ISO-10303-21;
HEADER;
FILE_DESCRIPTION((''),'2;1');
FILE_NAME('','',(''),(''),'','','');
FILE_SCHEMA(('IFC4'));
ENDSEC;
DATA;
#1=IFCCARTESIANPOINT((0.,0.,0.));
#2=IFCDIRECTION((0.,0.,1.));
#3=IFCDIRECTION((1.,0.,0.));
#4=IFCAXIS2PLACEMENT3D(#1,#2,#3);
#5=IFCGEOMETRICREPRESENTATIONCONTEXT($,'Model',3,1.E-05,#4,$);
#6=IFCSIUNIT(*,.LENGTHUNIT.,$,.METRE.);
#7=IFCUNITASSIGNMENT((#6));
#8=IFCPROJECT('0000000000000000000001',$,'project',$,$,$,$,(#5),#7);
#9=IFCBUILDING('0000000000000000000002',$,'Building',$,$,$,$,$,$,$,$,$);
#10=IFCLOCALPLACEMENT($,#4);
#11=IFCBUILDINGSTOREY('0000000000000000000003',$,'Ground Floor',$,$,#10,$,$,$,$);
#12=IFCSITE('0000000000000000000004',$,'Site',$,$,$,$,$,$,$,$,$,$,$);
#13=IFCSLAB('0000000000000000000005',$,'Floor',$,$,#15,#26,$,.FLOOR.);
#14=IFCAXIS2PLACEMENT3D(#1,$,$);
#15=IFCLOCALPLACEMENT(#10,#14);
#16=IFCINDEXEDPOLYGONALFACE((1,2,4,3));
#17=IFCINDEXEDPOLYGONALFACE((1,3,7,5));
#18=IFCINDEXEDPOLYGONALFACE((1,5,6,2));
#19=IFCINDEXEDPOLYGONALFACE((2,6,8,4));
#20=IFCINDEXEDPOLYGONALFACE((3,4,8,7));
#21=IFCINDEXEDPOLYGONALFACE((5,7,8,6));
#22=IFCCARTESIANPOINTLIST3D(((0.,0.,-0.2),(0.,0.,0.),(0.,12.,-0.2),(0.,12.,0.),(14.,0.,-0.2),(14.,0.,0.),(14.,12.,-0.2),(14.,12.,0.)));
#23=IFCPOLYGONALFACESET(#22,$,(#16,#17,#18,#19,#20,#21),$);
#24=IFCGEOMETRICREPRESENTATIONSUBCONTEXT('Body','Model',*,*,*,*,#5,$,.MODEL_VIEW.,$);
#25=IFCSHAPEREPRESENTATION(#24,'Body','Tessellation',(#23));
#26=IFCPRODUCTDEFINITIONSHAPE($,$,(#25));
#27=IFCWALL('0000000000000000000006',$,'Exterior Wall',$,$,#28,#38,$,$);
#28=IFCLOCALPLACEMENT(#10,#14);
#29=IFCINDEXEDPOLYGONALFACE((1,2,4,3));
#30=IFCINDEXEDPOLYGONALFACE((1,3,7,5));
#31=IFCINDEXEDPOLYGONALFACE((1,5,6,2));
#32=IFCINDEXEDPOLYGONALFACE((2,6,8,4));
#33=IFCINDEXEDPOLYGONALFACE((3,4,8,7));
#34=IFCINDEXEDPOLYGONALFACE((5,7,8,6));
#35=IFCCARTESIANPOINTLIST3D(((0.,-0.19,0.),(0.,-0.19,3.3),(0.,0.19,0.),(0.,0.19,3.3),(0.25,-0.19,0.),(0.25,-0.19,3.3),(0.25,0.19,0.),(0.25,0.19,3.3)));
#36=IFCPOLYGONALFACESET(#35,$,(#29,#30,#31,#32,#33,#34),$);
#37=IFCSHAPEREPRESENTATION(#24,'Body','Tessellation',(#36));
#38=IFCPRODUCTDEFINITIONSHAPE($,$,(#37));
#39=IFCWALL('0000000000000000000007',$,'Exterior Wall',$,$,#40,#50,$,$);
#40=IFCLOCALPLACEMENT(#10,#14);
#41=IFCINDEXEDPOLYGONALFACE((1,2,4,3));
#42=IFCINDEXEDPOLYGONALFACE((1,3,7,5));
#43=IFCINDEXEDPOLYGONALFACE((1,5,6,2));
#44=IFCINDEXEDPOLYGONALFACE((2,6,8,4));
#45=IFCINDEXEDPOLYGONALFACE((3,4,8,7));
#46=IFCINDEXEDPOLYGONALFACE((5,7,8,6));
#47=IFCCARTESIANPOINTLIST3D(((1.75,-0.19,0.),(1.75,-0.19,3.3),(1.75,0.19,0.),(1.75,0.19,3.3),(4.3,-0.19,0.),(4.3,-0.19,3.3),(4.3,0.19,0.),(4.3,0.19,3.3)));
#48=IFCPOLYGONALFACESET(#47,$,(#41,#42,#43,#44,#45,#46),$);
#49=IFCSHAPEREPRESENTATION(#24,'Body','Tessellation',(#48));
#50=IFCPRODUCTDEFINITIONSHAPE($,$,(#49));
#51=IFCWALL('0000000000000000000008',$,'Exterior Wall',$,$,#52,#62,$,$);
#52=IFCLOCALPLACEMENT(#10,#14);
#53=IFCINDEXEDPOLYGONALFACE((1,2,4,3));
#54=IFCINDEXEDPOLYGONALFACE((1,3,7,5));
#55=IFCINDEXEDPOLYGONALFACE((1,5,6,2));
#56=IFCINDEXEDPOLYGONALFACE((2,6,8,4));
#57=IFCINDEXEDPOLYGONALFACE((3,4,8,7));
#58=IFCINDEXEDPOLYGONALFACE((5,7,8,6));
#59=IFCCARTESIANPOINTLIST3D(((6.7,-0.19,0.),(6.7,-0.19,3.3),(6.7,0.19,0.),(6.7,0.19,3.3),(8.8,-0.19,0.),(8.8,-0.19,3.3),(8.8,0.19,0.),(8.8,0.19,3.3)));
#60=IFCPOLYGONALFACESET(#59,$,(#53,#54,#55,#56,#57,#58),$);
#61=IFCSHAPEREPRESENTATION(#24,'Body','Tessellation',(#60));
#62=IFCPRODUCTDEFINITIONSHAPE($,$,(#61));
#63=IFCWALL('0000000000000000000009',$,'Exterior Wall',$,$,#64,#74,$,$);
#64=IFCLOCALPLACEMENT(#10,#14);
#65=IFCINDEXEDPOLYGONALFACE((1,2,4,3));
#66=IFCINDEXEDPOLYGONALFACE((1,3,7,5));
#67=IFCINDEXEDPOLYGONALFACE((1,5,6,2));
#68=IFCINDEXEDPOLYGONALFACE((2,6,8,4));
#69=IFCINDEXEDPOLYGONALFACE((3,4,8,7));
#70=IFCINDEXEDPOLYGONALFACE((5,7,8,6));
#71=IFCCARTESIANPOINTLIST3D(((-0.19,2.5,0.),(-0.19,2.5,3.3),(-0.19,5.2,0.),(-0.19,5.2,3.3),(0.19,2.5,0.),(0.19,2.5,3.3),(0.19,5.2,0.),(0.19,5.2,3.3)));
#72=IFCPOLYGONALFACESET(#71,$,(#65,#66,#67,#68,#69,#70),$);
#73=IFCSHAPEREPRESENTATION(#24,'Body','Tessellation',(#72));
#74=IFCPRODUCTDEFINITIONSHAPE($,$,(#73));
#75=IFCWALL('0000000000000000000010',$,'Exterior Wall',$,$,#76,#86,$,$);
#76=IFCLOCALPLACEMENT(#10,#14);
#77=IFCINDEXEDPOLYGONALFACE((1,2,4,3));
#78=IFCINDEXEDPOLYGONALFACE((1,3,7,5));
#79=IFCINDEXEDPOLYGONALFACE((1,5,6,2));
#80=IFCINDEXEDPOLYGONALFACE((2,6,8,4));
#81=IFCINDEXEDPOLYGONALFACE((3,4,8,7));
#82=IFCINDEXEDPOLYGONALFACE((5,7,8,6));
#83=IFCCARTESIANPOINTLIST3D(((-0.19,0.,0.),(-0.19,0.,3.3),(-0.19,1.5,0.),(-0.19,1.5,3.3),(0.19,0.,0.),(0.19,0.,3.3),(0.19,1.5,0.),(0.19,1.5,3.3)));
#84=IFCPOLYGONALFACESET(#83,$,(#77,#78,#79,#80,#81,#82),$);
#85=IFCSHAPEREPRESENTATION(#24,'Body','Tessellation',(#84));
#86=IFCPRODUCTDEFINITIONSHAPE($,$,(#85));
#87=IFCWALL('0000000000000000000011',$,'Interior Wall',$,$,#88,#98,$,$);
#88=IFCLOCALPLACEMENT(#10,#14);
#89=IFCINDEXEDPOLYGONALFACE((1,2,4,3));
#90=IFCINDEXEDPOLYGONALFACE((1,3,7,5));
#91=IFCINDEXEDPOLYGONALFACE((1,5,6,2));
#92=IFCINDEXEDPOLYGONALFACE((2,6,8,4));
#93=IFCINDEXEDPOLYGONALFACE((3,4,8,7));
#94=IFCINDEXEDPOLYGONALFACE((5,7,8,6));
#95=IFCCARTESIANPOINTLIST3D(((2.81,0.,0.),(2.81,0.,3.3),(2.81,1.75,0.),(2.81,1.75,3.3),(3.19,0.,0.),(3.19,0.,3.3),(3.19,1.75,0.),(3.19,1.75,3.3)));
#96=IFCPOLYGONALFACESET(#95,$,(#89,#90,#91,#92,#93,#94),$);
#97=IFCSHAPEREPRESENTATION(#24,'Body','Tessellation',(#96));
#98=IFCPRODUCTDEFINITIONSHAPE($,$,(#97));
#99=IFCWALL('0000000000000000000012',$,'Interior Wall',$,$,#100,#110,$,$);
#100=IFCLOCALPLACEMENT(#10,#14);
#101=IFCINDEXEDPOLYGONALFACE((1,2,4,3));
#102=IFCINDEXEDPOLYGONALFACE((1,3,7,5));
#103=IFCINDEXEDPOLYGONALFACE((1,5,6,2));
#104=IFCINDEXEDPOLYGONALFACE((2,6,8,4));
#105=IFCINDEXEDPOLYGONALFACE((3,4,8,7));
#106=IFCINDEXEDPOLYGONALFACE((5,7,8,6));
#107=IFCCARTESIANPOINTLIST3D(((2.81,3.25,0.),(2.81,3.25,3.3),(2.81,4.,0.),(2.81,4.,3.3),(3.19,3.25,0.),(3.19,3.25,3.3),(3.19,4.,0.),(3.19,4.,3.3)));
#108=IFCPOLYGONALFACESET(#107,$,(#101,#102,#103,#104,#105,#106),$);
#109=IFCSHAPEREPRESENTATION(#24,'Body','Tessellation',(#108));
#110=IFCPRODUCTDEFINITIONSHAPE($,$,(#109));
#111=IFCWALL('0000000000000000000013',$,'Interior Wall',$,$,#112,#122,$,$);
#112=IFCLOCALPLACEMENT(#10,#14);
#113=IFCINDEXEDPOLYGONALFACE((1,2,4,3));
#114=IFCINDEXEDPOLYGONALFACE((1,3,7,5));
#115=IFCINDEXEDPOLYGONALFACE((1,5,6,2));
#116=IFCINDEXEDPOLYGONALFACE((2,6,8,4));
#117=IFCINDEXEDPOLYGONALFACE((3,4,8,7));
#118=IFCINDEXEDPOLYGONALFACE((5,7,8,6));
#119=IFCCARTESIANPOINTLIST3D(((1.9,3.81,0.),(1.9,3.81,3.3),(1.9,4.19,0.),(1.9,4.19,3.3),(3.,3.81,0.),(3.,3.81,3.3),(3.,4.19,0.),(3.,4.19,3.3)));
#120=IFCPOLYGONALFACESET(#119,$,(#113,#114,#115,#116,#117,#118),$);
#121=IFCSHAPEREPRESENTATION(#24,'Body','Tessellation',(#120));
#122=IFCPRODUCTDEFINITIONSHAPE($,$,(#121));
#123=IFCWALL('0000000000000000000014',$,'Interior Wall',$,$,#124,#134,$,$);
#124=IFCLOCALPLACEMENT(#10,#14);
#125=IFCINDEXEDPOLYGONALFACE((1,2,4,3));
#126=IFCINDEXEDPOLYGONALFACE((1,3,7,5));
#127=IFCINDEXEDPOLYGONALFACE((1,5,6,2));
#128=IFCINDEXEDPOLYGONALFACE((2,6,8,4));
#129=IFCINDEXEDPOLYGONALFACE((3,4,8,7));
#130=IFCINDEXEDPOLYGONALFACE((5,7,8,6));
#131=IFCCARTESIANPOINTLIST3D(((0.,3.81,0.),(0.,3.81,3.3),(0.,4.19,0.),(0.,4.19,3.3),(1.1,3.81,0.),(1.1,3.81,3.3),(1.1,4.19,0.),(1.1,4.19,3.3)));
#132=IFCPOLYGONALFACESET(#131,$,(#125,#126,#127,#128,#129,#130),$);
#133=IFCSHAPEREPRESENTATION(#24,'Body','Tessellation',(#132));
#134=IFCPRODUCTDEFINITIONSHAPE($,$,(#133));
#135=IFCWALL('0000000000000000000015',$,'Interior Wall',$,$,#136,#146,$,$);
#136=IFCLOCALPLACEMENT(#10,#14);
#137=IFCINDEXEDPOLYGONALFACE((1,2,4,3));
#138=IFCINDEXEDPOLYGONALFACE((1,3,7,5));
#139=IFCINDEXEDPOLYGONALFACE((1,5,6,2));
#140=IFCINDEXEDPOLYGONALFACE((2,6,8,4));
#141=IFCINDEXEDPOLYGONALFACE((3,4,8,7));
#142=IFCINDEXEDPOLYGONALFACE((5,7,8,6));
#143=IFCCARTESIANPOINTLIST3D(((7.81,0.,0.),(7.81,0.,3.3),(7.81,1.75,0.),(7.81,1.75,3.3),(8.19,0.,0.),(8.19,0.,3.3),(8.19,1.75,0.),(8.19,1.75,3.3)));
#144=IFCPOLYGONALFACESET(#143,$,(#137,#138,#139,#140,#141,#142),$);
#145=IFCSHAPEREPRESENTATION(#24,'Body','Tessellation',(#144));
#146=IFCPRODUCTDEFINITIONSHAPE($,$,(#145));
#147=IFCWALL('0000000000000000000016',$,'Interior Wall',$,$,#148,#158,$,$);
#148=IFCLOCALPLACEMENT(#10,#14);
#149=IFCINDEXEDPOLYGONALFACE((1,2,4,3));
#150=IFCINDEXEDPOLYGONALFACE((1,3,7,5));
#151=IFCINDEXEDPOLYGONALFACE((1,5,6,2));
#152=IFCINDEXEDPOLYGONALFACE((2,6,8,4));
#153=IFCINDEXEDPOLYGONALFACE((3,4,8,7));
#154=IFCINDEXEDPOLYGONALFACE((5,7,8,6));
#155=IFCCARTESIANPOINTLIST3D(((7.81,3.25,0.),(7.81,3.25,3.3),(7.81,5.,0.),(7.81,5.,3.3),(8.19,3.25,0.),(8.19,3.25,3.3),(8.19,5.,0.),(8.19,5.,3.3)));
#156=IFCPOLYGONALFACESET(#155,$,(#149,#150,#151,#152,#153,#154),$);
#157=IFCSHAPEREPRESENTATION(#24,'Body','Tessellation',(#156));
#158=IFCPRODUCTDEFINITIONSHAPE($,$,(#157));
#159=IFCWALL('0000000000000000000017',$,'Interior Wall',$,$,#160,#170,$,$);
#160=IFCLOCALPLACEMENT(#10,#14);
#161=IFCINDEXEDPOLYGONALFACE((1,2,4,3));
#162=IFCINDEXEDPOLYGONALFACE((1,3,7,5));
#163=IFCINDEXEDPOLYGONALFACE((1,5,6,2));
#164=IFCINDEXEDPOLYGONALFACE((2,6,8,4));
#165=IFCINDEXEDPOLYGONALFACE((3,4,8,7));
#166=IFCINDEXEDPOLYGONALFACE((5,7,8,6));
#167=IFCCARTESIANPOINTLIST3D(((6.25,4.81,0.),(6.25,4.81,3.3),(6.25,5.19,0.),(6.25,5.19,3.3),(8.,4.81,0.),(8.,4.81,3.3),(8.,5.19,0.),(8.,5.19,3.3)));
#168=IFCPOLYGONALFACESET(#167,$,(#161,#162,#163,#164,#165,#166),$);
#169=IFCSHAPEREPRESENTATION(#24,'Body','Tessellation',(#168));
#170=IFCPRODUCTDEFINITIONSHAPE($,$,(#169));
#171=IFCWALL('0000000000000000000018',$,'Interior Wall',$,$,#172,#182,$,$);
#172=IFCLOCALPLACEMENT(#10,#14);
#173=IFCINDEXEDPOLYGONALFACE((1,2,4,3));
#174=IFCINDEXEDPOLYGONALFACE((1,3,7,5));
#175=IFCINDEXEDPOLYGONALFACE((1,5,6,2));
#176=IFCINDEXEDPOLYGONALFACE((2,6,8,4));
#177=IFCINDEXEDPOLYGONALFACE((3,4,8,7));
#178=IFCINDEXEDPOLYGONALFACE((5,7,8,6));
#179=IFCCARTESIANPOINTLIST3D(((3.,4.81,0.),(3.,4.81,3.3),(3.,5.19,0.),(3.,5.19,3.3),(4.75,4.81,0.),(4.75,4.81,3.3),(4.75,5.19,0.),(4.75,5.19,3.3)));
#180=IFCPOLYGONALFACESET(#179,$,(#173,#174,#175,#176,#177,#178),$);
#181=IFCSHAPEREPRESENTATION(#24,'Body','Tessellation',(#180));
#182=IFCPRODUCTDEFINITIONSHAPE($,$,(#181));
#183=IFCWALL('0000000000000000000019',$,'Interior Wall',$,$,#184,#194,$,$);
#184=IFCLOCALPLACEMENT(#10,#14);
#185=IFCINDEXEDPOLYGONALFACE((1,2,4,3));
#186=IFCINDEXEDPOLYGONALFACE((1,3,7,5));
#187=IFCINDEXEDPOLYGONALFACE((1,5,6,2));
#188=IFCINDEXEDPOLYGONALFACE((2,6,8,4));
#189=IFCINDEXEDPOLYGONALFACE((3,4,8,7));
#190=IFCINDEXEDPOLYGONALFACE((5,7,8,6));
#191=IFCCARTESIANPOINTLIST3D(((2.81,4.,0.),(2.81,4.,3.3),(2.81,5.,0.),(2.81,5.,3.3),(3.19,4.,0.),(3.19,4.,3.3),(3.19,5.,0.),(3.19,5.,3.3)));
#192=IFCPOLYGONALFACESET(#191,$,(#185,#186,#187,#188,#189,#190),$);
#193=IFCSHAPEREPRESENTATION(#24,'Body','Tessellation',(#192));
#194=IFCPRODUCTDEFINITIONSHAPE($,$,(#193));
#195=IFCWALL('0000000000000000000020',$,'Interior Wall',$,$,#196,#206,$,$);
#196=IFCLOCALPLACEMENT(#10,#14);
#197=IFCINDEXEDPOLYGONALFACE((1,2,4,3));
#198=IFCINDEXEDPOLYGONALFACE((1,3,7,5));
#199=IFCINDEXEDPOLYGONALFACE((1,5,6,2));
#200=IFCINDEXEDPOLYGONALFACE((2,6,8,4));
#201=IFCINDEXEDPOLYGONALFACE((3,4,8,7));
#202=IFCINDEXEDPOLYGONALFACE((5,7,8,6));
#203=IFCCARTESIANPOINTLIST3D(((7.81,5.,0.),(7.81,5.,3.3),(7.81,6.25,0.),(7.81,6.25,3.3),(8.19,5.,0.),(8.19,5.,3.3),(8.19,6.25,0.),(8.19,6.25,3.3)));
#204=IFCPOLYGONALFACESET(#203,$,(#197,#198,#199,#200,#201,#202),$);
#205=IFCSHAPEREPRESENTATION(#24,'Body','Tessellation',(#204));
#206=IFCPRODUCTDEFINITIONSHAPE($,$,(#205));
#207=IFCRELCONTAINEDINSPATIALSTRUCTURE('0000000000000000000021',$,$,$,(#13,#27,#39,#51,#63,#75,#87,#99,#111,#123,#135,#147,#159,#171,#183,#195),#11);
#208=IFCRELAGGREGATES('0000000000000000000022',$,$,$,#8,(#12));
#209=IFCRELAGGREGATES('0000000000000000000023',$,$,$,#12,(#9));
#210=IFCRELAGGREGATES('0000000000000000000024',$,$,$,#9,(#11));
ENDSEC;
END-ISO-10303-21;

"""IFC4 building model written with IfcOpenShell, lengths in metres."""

from ifc_helpers import new_model, si_unit, frame, origin_with_axes, place, context, subcontext, project, spatial, indexed_curve, outline, extrude, element, save


model = new_model("IFC4")

# Units and contexts
model_context = context("Model", 3, precision=1e-05, world=origin_with_axes())
body_context = subcontext(model_context, "Body", "Model", "MODEL_VIEW")
ifc_project = project(units=[si_unit("LENGTHUNIT", "METRE")], contexts=[model_context])

# Site, building, storey
site = spatial("IfcSite", under=ifc_project, Name="Site")
building = spatial("IfcBuilding", under=site, Name="Building")
storey_placement = place(None, origin_with_axes())
storey = spatial("IfcBuildingStorey", under=building, at=storey_placement, Name="Ground Floor")

# Slab
slab_placement = place(storey_placement, frame((0.0, 0.0, -0.2), z_axis=(0.0, 0.0, 1.0), x_axis=(1.0, 0.0, 0.0)))
element("IfcSlab", 1, at=slab_placement, inside=storey, Name="Floor", PredefinedType="FLOOR", context=body_context, shape_type="SweptSolid", body=[
    extrude(outline(indexed_curve([(0.0, 0.0), (14.0, 0.0), (14.0, 12.0), (0.0, 12.0)])), None, (0.0, 0.0, 1.0), 0.2),
])

# Walls
wall_1_placement = place(storey_placement, origin_with_axes())
element("IfcWall", 2, at=wall_1_placement, inside=storey, Name="Exterior Wall", context=body_context, shape_type="SweptSolid", body=[
    extrude(outline(indexed_curve([(0.0, 0.0), (0.0, 0.38), (0.25, 0.38), (0.25, 0.0), (0.0, 0.0)], self_intersect=False)), frame((0.0, -0.19, 0.0), z_axis=(0.0, 0.0, 1.0), x_axis=(1.0, 0.0, 0.0)), (0.0, 0.0, 1.0), 3.3),
])
wall_2_placement = place(storey_placement, frame((1.75, 0.0, 0.0), z_axis=(0.0, 0.0, 1.0), x_axis=(1.0, 0.0, 0.0)))
element("IfcWall", 3, at=wall_2_placement, inside=storey, Name="Exterior Wall", context=body_context, shape_type="SweptSolid", body=[
    extrude(outline(indexed_curve([(0.0, 0.0), (0.0, 0.38), (2.55, 0.38), (2.55, 0.0), (0.0, 0.0)], self_intersect=False)), frame((0.0, -0.19, 0.0), z_axis=(0.0, 0.0, 1.0), x_axis=(1.0, 0.0, 0.0)), (0.0, 0.0, 1.0), 3.3),
])
wall_3_placement = place(storey_placement, frame((6.7, 0.0, 0.0), z_axis=(0.0, 0.0, 1.0), x_axis=(1.0, 0.0, 0.0)))
element("IfcWall", 4, at=wall_3_placement, inside=storey, Name="Exterior Wall", context=body_context, shape_type="SweptSolid", body=[
    extrude(outline(indexed_curve([(0.0, 0.0), (0.0, 0.38), (2.1, 0.38), (2.1, 0.0), (0.0, 0.0)], self_intersect=False)), frame((0.0, -0.19, 0.0), z_axis=(0.0, 0.0, 1.0), x_axis=(1.0, 0.0, 0.0)), (0.0, 0.0, 1.0), 3.3),
])
wall_4_placement = place(storey_placement, frame((0.0, 5.2, 0.0), z_axis=(0.0, 0.0, 1.0), x_axis=(0.0, -1.0, 0.0)))
element("IfcWall", 5, at=wall_4_placement, inside=storey, Name="Exterior Wall", context=body_context, shape_type="SweptSolid", body=[
    extrude(outline(indexed_curve([(0.0, 0.0), (0.0, 0.38), (2.7, 0.38), (2.7, 0.0), (0.0, 0.0)], self_intersect=False)), frame((0.0, -0.19, 0.0), z_axis=(0.0, 0.0, 1.0), x_axis=(1.0, 0.0, 0.0)), (0.0, 0.0, 1.0), 3.3),
])
wall_5_placement = place(storey_placement, frame((0.0, 1.5, 0.0), z_axis=(0.0, 0.0, 1.0), x_axis=(0.0, -1.0, 0.0)))
element("IfcWall", 6, at=wall_5_placement, inside=storey, Name="Exterior Wall", context=body_context, shape_type="SweptSolid", body=[
    extrude(outline(indexed_curve([(0.0, 0.0), (0.0, 0.38), (1.5, 0.38), (1.5, 0.0), (0.0, 0.0)], self_intersect=False)), frame((0.0, -0.19, 0.0), z_axis=(0.0, 0.0, 1.0), x_axis=(1.0, 0.0, 0.0)), (0.0, 0.0, 1.0), 3.3),
])
wall_6_placement = place(storey_placement, frame((3.0, 0.0, 0.0), z_axis=(0.0, 0.0, 1.0), x_axis=(0.0, 1.0, 0.0)))
element("IfcWall", 7, at=wall_6_placement, inside=storey, Name="Interior Wall", context=body_context, shape_type="SweptSolid", body=[
    extrude(outline(indexed_curve([(0.0, 0.0), (0.0, 0.38), (1.75, 0.38), (1.75, 0.0), (0.0, 0.0)], self_intersect=False)), frame((0.0, -0.19, 0.0), z_axis=(0.0, 0.0, 1.0), x_axis=(1.0, 0.0, 0.0)), (0.0, 0.0, 1.0), 3.3),
])
wall_7_placement = place(storey_placement, frame((3.0, 3.25, 0.0), z_axis=(0.0, 0.0, 1.0), x_axis=(0.0, 1.0, 0.0)))
element("IfcWall", 8, at=wall_7_placement, inside=storey, Name="Interior Wall", context=body_context, shape_type="SweptSolid", body=[
    extrude(outline(indexed_curve([(0.0, 0.0), (0.0, 0.38), (0.75, 0.38), (0.75, 0.0), (0.0, 0.0)], self_intersect=False)), frame((0.0, -0.19, 0.0), z_axis=(0.0, 0.0, 1.0), x_axis=(1.0, 0.0, 0.0)), (0.0, 0.0, 1.0), 3.3),
])
for number, where, z_axis, x_axis, name in (
    (9, (3.0, 4.0, 0.0), (0.0, 0.0, 1.0), (-1.0, 0.0, 0.0), "Interior Wall"),
    (10, (1.1, 4.0, 0.0), (0.0, 0.0, 1.0), (-1.0, 0.0, 0.0), "Interior Wall"),
):
    element("IfcWall", number, at=place(storey_placement, frame(where, z_axis=z_axis, x_axis=x_axis)), inside=storey, Name=name, context=body_context, shape_type="SweptSolid", body=[
        extrude(outline(indexed_curve([(0.0, 0.0), (0.0, 0.38), (1.1, 0.38), (1.1, 0.0), (0.0, 0.0)], self_intersect=False)), frame((0.0, -0.19, 0.0), z_axis=(0.0, 0.0, 1.0), x_axis=(1.0, 0.0, 0.0)), (0.0, 0.0, 1.0), 3.3),
    ])
for number, where, z_axis, x_axis, name in (
    (11, (8.0, 0.0, 0.0), (0.0, 0.0, 1.0), (0.0, 1.0, 0.0), "Interior Wall"),
    (12, (8.0, 3.25, 0.0), (0.0, 0.0, 1.0), (0.0, 1.0, 0.0), "Interior Wall"),
    (13, (8.0, 5.0, 0.0), (0.0, 0.0, 1.0), (-1.0, 0.0, 0.0), "Interior Wall"),
    (14, (4.75, 5.0, 0.0), (0.0, 0.0, 1.0), (-1.0, 0.0, 0.0), "Interior Wall"),
):
    element("IfcWall", number, at=place(storey_placement, frame(where, z_axis=z_axis, x_axis=x_axis)), inside=storey, Name=name, context=body_context, shape_type="SweptSolid", body=[
        extrude(outline(indexed_curve([(0.0, 0.0), (0.0, 0.38), (1.75, 0.38), (1.75, 0.0), (0.0, 0.0)], self_intersect=False)), frame((0.0, -0.19, 0.0), z_axis=(0.0, 0.0, 1.0), x_axis=(1.0, 0.0, 0.0)), (0.0, 0.0, 1.0), 3.3),
    ])
wall_8_placement = place(storey_placement, frame((3.0, 5.0, 0.0), z_axis=(0.0, 0.0, 1.0), x_axis=(0.0, -1.0, 0.0)))
element("IfcWall", 15, at=wall_8_placement, inside=storey, Name="Interior Wall", context=body_context, shape_type="SweptSolid", body=[
    extrude(outline(indexed_curve([(0.0, 0.0), (0.0, 0.38), (1.0, 0.38), (1.0, 0.0), (0.0, 0.0)], self_intersect=False)), frame((0.0, -0.19, 0.0), z_axis=(0.0, 0.0, 1.0), x_axis=(1.0, 0.0, 0.0)), (0.0, 0.0, 1.0), 3.3),
])
wall_9_placement = place(storey_placement, frame((8.0, 5.0, 0.0), z_axis=(0.0, 0.0, 1.0), x_axis=(0.0, 1.0, 0.0)))
element("IfcWall", 16, at=wall_9_placement, inside=storey, Name="Interior Wall", context=body_context, shape_type="SweptSolid", body=[
    extrude(outline(indexed_curve([(0.0, 0.0), (0.0, 0.38), (1.25, 0.38), (1.25, 0.0), (0.0, 0.0)], self_intersect=False)), frame((0.0, -0.19, 0.0), z_axis=(0.0, 0.0, 1.0), x_axis=(1.0, 0.0, 0.0)), (0.0, 0.0, 1.0), 3.3),
])

save(model, "model.ifc")
